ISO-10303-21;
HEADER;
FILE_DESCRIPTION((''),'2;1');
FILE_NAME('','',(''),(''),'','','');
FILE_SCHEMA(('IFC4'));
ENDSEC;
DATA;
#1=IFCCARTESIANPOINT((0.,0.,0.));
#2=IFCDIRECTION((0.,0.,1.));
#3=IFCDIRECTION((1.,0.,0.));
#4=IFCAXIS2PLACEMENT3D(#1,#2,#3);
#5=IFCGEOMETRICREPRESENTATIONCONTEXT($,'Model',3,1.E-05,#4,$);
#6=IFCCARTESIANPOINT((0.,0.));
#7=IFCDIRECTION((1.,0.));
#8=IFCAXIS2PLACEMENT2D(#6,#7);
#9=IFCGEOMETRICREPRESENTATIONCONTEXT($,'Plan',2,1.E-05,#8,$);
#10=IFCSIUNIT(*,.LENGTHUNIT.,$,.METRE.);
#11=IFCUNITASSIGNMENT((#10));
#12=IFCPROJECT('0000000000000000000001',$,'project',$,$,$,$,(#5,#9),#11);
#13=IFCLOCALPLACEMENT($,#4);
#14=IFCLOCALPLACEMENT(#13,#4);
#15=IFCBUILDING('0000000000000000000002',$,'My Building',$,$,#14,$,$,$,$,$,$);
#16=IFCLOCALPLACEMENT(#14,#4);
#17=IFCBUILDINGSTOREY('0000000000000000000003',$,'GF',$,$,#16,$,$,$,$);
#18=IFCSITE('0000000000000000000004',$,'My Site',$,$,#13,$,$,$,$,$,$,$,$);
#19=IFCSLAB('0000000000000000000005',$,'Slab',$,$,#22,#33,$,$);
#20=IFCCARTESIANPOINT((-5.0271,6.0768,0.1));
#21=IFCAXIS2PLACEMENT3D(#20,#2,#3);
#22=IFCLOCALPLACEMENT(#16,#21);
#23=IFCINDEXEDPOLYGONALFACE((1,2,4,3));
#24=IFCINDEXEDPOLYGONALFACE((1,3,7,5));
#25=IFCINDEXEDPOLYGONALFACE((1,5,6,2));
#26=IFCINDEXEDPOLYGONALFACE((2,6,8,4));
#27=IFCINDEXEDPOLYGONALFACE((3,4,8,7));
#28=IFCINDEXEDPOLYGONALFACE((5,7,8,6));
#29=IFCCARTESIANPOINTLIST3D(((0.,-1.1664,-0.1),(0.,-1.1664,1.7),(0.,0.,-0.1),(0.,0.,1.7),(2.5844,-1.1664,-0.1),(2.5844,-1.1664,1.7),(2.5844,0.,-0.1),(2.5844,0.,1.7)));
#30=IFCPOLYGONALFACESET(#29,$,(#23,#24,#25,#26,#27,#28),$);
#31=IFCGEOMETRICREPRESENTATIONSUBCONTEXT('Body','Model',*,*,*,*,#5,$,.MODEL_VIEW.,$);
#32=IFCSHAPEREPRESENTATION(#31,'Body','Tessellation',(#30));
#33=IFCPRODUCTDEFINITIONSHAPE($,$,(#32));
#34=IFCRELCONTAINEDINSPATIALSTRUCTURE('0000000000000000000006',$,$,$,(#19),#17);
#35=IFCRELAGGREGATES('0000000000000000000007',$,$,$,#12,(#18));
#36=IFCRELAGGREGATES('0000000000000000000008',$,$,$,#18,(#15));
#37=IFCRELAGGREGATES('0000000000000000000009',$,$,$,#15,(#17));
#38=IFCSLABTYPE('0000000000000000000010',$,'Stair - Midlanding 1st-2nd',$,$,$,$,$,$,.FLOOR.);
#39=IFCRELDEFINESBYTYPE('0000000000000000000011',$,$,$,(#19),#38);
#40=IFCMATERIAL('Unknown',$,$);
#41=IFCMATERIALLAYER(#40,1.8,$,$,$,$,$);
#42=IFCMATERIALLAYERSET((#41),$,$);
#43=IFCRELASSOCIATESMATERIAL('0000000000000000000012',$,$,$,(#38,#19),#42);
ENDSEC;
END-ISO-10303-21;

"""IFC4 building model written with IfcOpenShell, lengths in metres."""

from ifc_helpers import new_model, si_unit, frame, origin_with_axes, origin_2d_with_axis, place, context, subcontext, project, spatial, indexed_curve, outline, extrude, material, layer, layer_set, layer_usage, type_object, element, save


model = new_model("IFC4")

# Units and contexts
model_context = context("Model", 3, precision=1e-05, world=origin_with_axes())
plan_context = context("Plan", 2, precision=1e-05, world=origin_2d_with_axis())
body_context_1 = subcontext(model_context, "Body", "Model", "MODEL_VIEW")
ifc_project = project(units=[si_unit("LENGTHUNIT", "METRE")], contexts=[model_context, plan_context])

# Site, building, storey
site_placement = place(None, origin_with_axes())
site = spatial("IfcSite", under=ifc_project, at=site_placement, Name="My Site")
building_placement = place(site_placement, origin_with_axes())
building = spatial("IfcBuilding", under=site, at=building_placement, Name="My Building")
storey_placement = place(building_placement, origin_with_axes())
storey = spatial("IfcBuildingStorey", under=building, at=storey_placement, Name="GF")

# Shared definitions
ifc_material = material(Name="Unknown")

# Slab
ifc_layer_1 = layer(ifc_material, 1.8)
ifc_layer_set_1 = layer_set([ifc_layer_1])
ifc_layer_usage_1 = layer_usage(ifc_layer_set_1, "AXIS3", "POSITIVE", -0.1)
slab_type_1 = type_object("IfcSlabType", Name="Stair - Midlanding 1st-2nd", PredefinedType="FLOOR", material=ifc_layer_set_1)
slab_1_placement = place(storey_placement, frame((-5.0271, 6.0768, 0.1), z_axis=(0.0, 0.0, 1.0), x_axis=(1.0, 0.0, 0.0)))
element("IfcSlab", 1, at=slab_1_placement, inside=storey, type_object=slab_type_1, material=ifc_layer_usage_1, Name="Slab", context=body_context_1, shape_type="SweptSolid", body=[
    extrude(outline(indexed_curve([(0.0, 0.0), (2.5844, 0.0), (2.5844, -1.1664), (0.0, -1.1664), (0.0, 0.0)])), frame((0.0, 0.0, -0.1), z_axis=(0.0, 0.0, 1.0), x_axis=(1.0, 0.0, 0.0)), (0.0, 0.0, 1.0), 1.8),
])

save(model, "model.ifc")
